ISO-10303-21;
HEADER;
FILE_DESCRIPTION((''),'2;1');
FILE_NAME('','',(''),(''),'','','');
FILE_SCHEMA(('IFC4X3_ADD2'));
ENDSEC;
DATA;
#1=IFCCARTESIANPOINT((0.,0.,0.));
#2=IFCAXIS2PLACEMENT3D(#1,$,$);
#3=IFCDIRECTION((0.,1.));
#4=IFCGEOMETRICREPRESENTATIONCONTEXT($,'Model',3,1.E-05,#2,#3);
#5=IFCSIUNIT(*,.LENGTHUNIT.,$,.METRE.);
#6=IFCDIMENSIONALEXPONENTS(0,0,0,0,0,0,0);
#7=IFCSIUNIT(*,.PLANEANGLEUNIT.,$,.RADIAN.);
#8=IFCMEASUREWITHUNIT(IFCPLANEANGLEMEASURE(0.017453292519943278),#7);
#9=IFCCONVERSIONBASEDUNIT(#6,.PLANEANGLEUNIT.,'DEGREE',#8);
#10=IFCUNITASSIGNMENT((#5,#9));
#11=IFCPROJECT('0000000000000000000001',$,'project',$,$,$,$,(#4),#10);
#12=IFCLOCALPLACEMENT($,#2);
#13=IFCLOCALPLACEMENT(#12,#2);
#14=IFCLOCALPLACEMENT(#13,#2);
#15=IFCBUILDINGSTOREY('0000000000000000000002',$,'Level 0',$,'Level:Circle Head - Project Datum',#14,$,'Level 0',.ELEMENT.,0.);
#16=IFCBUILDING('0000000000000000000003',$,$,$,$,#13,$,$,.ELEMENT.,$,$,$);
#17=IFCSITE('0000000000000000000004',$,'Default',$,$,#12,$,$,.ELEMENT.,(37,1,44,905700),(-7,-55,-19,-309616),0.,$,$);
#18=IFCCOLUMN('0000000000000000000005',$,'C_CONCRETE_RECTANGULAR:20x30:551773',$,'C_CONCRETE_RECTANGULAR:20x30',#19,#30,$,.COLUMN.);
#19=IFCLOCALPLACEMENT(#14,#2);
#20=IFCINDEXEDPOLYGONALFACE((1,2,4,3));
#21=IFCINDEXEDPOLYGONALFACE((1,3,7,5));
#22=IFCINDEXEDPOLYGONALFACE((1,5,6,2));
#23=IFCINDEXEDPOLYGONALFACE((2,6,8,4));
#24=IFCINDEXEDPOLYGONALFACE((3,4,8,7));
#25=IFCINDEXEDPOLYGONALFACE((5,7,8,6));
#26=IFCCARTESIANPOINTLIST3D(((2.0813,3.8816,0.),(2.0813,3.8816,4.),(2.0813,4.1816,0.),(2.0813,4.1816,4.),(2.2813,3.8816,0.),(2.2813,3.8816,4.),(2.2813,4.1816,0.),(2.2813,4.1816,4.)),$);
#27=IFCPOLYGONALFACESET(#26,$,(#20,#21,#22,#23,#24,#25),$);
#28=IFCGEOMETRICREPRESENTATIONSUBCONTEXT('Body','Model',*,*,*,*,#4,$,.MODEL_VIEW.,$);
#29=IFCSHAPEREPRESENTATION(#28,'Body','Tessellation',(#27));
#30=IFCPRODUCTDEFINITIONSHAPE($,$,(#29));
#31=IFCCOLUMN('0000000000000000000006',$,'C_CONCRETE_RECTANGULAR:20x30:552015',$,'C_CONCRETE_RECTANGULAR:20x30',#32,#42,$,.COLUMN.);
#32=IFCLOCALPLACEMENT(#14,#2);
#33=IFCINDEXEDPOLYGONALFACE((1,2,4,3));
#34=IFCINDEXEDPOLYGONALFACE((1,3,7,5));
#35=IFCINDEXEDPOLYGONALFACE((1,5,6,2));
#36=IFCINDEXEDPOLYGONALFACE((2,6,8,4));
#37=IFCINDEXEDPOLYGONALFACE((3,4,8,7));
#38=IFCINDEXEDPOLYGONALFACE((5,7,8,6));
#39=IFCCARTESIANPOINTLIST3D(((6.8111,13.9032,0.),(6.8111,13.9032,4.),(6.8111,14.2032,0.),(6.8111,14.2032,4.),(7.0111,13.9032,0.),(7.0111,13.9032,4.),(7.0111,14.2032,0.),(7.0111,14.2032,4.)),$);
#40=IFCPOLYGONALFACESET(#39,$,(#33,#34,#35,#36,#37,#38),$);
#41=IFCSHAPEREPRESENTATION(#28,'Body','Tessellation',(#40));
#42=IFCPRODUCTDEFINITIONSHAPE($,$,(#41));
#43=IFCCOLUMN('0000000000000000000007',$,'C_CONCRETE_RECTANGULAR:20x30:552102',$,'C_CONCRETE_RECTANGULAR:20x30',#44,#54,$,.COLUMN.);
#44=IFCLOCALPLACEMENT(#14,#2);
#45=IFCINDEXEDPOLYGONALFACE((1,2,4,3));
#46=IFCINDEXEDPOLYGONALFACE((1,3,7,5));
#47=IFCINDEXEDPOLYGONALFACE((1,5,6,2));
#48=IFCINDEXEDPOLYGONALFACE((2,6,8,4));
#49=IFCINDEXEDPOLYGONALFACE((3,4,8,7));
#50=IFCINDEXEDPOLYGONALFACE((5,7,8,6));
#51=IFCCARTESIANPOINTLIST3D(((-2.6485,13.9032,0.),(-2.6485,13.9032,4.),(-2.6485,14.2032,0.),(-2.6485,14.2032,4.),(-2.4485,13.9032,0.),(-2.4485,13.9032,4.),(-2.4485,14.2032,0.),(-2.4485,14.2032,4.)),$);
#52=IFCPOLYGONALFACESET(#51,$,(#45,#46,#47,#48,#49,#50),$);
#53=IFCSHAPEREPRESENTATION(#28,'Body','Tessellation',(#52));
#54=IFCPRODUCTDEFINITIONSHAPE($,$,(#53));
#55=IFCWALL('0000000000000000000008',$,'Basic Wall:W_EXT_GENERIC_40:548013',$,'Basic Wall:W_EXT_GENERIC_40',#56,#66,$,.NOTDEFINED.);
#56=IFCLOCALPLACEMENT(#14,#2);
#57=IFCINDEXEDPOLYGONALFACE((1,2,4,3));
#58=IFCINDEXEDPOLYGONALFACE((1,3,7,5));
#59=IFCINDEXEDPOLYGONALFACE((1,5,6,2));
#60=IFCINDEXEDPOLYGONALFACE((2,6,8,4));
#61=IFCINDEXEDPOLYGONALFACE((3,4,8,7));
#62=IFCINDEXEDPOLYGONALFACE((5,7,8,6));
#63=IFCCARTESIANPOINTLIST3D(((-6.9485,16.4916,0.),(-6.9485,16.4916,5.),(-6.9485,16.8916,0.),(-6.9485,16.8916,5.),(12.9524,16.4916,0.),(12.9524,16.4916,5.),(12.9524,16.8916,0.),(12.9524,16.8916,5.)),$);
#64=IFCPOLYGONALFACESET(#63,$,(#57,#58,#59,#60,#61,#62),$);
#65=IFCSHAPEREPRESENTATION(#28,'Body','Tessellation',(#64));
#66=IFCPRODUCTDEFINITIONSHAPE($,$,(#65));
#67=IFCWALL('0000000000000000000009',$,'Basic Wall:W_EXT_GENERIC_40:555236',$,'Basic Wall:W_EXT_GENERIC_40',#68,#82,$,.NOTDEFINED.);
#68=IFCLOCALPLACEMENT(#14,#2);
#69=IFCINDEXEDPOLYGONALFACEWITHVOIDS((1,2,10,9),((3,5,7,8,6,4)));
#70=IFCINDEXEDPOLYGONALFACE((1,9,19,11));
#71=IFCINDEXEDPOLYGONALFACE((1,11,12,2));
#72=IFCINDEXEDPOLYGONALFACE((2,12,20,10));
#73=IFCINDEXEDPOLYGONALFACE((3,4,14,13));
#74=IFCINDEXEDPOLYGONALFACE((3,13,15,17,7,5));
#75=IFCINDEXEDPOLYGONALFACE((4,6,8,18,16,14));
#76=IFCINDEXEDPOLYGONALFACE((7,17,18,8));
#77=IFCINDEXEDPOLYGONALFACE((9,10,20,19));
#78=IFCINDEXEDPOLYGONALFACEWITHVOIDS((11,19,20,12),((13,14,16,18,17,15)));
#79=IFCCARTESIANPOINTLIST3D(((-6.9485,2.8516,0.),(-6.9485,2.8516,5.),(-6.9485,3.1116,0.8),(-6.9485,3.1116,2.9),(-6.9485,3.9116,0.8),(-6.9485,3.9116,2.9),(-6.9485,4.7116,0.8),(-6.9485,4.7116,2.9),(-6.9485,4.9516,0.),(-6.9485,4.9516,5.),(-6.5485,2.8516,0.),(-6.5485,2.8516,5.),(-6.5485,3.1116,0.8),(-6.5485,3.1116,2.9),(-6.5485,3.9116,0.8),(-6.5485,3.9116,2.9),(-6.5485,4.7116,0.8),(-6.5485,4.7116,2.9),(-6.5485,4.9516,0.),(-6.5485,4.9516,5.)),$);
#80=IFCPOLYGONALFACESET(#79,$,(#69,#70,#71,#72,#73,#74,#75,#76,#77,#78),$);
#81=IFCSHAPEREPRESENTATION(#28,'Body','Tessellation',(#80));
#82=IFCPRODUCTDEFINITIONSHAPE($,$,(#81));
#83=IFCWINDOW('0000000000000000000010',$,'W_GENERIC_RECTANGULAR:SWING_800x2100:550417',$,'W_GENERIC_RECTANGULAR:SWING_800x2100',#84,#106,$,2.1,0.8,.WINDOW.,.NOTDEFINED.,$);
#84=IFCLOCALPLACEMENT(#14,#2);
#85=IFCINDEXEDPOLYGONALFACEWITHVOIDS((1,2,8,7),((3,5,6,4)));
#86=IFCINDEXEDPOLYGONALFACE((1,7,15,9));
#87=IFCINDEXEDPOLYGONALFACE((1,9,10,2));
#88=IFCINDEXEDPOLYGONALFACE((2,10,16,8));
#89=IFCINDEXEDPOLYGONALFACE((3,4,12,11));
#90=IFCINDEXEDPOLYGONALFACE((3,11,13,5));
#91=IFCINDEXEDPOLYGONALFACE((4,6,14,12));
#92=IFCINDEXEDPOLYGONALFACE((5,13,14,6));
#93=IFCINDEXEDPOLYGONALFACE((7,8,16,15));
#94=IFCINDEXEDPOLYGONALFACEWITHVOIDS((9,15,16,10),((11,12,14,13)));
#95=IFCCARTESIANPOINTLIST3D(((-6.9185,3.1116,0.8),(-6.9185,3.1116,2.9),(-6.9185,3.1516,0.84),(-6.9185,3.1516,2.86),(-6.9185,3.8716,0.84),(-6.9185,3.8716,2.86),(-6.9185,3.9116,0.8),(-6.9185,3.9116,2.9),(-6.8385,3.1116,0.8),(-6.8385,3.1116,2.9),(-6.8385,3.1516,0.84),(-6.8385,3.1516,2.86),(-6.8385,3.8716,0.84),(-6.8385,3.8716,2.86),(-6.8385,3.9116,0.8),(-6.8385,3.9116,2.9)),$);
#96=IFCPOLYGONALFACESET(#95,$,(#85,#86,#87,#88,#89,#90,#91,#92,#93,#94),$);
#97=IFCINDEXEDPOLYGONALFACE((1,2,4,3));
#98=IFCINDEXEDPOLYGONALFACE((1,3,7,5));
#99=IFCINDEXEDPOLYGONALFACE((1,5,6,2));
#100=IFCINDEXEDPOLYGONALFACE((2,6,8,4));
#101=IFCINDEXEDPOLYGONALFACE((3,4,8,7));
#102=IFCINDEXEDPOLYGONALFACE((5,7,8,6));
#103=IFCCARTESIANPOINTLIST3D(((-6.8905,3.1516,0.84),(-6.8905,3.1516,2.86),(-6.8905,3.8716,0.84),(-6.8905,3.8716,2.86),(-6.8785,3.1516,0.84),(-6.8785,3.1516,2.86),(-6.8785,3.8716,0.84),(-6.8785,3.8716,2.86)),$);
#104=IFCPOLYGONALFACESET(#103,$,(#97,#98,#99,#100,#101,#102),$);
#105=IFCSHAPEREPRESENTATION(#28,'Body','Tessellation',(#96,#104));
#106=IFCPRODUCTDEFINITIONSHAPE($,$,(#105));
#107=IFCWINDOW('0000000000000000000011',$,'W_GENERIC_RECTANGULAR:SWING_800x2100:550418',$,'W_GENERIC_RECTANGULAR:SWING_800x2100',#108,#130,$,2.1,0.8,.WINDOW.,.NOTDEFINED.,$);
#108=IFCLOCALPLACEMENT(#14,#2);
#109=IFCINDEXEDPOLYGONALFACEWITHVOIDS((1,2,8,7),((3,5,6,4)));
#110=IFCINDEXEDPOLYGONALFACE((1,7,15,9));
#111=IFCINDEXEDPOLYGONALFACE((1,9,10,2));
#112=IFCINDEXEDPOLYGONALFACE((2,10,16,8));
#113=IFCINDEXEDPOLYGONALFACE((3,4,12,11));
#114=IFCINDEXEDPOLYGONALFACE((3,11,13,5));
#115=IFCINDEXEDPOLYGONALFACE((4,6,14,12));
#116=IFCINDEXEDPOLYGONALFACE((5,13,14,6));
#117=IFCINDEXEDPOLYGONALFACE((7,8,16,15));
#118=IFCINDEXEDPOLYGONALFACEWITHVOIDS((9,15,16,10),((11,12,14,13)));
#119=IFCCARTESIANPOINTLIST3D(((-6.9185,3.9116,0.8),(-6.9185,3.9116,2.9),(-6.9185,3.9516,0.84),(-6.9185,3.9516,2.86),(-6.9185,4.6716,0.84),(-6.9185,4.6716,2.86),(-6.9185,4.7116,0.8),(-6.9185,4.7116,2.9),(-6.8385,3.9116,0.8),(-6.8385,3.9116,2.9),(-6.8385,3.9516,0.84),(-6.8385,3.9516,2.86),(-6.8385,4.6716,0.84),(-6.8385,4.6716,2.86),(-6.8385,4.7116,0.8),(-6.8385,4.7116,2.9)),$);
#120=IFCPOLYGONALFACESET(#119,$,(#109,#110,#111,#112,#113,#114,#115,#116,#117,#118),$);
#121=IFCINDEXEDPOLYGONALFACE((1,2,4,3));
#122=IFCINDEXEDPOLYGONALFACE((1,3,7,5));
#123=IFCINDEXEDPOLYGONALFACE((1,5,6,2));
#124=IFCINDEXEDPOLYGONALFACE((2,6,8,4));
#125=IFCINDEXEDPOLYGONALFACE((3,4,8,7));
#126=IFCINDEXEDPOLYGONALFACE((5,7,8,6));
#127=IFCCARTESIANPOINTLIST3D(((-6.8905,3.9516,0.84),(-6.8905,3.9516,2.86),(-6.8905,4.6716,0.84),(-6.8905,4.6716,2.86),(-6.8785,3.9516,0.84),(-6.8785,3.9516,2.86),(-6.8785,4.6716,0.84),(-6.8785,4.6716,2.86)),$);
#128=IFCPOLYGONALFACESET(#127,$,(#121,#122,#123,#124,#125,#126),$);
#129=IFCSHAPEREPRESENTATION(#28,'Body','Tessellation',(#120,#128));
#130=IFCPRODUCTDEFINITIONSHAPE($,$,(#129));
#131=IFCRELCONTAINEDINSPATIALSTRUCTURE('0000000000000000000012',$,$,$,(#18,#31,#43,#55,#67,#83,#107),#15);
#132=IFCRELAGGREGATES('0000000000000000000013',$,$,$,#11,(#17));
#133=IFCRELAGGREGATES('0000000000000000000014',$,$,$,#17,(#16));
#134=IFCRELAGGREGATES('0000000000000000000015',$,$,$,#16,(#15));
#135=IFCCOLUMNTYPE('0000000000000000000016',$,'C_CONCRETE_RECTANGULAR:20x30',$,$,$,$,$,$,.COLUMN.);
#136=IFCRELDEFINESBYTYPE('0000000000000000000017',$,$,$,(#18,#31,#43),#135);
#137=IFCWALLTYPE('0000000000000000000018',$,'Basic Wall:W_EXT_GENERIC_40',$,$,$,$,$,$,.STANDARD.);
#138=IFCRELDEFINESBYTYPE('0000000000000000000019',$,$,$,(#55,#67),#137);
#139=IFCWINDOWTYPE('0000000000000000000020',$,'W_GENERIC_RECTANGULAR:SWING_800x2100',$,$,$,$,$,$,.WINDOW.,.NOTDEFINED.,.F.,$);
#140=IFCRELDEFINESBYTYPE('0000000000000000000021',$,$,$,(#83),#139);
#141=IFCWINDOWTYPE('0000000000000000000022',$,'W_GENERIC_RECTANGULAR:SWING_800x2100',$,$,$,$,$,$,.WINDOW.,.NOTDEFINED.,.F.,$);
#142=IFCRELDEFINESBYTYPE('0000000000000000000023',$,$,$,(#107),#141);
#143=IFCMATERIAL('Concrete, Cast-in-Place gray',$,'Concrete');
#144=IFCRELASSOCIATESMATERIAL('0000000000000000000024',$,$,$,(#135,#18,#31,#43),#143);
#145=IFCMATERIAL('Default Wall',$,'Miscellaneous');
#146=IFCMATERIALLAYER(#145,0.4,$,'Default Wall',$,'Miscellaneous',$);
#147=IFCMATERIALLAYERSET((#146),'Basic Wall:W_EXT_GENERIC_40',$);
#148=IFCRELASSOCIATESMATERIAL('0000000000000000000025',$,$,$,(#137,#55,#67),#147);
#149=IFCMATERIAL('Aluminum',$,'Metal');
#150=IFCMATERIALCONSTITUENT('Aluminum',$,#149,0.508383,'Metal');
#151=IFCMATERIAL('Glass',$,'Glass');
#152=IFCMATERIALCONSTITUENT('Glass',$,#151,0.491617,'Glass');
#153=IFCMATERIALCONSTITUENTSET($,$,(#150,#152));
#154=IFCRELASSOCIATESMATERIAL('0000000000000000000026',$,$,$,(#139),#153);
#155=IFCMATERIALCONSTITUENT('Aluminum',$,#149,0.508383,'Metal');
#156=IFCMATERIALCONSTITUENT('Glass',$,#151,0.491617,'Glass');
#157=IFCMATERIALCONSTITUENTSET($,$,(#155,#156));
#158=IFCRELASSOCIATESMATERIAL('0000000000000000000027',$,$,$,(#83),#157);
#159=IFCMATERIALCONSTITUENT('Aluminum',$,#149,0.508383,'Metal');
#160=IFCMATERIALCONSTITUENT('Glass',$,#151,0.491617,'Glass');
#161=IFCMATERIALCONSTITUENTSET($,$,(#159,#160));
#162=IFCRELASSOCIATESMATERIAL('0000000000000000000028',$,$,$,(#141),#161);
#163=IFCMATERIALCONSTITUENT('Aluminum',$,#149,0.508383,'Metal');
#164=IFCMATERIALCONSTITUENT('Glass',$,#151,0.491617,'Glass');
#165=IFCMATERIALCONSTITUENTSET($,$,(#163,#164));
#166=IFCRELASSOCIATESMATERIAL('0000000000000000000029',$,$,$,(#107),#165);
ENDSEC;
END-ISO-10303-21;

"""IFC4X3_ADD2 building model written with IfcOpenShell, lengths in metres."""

from ifc_helpers import new_model, entity, si_unit, converted_unit, direction, frame, frame_2d, origin, origin_2d_with_axis, place, context, subcontext, project, spatial, polyline, rectangle, outline, extrude, source, transform, mapped, material, layer, layer_set, constituent, constituent_set, material_profile, profile_set, profile_usage, type_object, type_shapes, element, fill, save


model = new_model("IFC4X3_ADD2")

# Units and contexts
model_context = context("Model", 3, precision=1e-05, world=origin(), true_north=direction((0.0, 1.0)))
body_context = subcontext(model_context, "Body", "Model", "MODEL_VIEW")
ifc_project = project(units=[si_unit("LENGTHUNIT", "METRE"), converted_unit("PLANEANGLEUNIT", "DEGREE", entity("IfcPlaneAngleMeasure", 0.017453292519943278), si_unit("PLANEANGLEUNIT", "RADIAN"), dimensions=[0, 0, 0, 0, 0, 0, 0])], contexts=[model_context])

# Site, building, storey
site_placement = place(None, origin())
site = spatial("IfcSite", under=ifc_project, at=site_placement, Name="Default", CompositionType="ELEMENT", RefLatitude=(37, 1, 44, 905700), RefLongitude=(-7, -55, -19, -309616), RefElevation=0.0)
building_placement = place(site_placement, origin())
building = spatial("IfcBuilding", under=site, at=building_placement, CompositionType="ELEMENT")
storey_placement = place(building_placement, origin())
storey = spatial("IfcBuildingStorey", under=building, at=storey_placement, Name="Level 0", ObjectType="Level:Circle Head - Project Datum", LongName="Level 0", CompositionType="ELEMENT", Elevation=0.0)

# Columns
ifc_material_1 = material(Name="Concrete, Cast-in-Place gray", Category="Concrete")
ifc_material_profile = material_profile(ifc_material_1, rectangle(XDim=0.2, YDim=0.3, at=origin_2d_with_axis()), Name="20x30")
ifc_profile_set = profile_set([ifc_material_profile], Name="20x30")
ifc_profile_usage = profile_usage(ifc_profile_set)
column_type = type_object("IfcColumnType", Name="C_CONCRETE_RECTANGULAR:20x30", PredefinedType="COLUMN", material=ifc_profile_set)
shared_shape_1 = source(origin(), body_context, "Body", "SweptSolid", [
    extrude(rectangle(XDim=0.2, YDim=0.3, at=origin_2d_with_axis()), frame((0.0, 0.0, 0.0), z_axis=(0.0, 0.0, 1.0), x_axis=(-1.0, 0.0, 0.0)), (0.0, 0.0, 1.0), 4.0),
])
type_shapes(column_type, [shared_shape_1])
for number, where, name in (
    (1, (2.1813, 4.0316, 0.0), "C_CONCRETE_RECTANGULAR:20x30:551773"),
    (2, (6.9111, 14.0532, 0.0), "C_CONCRETE_RECTANGULAR:20x30:552015"),
    (3, (-2.5485, 14.0532, 0.0), "C_CONCRETE_RECTANGULAR:20x30:552102"),
):
    element("IfcColumn", number, at=place(storey_placement, frame(where)), inside=storey, type_object=column_type, material=ifc_profile_usage, Name=name, ObjectType="C_CONCRETE_RECTANGULAR:20x30", PredefinedType="COLUMN", context=body_context, shape_type="MappedRepresentation", body=[
        mapped(shared_shape_1, transform((0.0, 0.0, 0.0), scale=1.0)),
    ])

# Wall
ifc_material_2 = material(Name="Default Wall", Category="Miscellaneous")
ifc_layer_1 = layer(ifc_material_2, 0.4, Name="Default Wall", Category="Miscellaneous")
ifc_layer_set_1 = layer_set([ifc_layer_1], Name="Basic Wall:W_EXT_GENERIC_40")
wall_type_1 = type_object("IfcWallType", Name="Basic Wall:W_EXT_GENERIC_40", PredefinedType="STANDARD", material=ifc_layer_set_1)
wall_1_placement = place(storey_placement, frame((-6.9485, 16.6916, 0.0)))
element("IfcWall", 4, at=wall_1_placement, inside=storey, type_object=wall_type_1, material=ifc_layer_set_1, Name="Basic Wall:W_EXT_GENERIC_40:548013", ObjectType="Basic Wall:W_EXT_GENERIC_40", PredefinedType="NOTDEFINED", context=body_context, shape_type="SweptSolid", body=[
    extrude(rectangle(XDim=19.9008, YDim=0.4, at=frame_2d((9.9504, 0.0), x_axis=(-1.0, 0.0))), origin(), (0.0, 0.0, 1.0), 5.0),
])

# Wall, openings, windows
wall_2_placement = place(storey_placement, frame((-6.7485, 4.9516, 0.0), z_axis=(0.0, 0.0, 1.0), x_axis=(0.0, -1.0, 0.0)))
wall_2 = element("IfcWall", 5, at=wall_2_placement, inside=storey, type_object=wall_type_1, material=ifc_layer_set_1, Name="Basic Wall:W_EXT_GENERIC_40:555236", ObjectType="Basic Wall:W_EXT_GENERIC_40", PredefinedType="NOTDEFINED", context=body_context, shape_type="SweptSolid", body=[
    extrude(rectangle(XDim=2.1, YDim=0.4, at=frame_2d((1.05, 0.0), x_axis=(-1.0, 0.0))), origin(), (0.0, 0.0, 1.0), 5.0),
])
opening_1_placement = place(wall_2_placement, frame((1.04, -0.2, 0.8)))
opening_1 = element("IfcOpeningElement", 6, at=opening_1_placement, cuts=wall_2, PredefinedType="OPENING", context=body_context, shape_type="SweptSolid", body=[
    extrude(rectangle(XDim=2.1, YDim=0.8, at=frame_2d((1.05, 0.4), x_axis=(-1.0, 0.0))), frame((0.0, 0.0, 0.0), z_axis=(0.0, 1.0, 0.0), x_axis=(0.0, 0.0, 1.0)), (0.0, 0.0, 1.0), 0.4),
])
opening_2_placement = place(wall_2_placement, frame((4.9516, 6.7485, 0.8), z_axis=(0.0, 0.0, 1.0), x_axis=(0.0, 1.0, 0.0)))
element("IfcOpeningElement", 7, at=opening_2_placement, cuts=wall_2, PredefinedType="OPENING", context=body_context, shape_type="SweptSolid", body=[
    extrude(rectangle(XDim=2.1, YDim=0.8, at=origin_2d_with_axis()), frame((-8.4725, 3.5116, 1.05), z_axis=(1.0, 0.0, 0.0), x_axis=(0.0, 0.0, -1.0)), (0.0, 0.0, 1.0), 3.048),
])
opening_3_placement = place(wall_2_placement, frame((0.24, -0.2, 0.8)))
opening_3 = element("IfcOpeningElement", 8, at=opening_3_placement, cuts=wall_2, PredefinedType="OPENING", context=body_context, shape_type="SweptSolid", body=[
    extrude(rectangle(XDim=2.1, YDim=0.8, at=frame_2d((1.05, 0.4), x_axis=(-1.0, 0.0))), frame((0.0, 0.0, 0.0), z_axis=(0.0, 1.0, 0.0), x_axis=(0.0, 0.0, 1.0)), (0.0, 0.0, 1.0), 0.4),
])
opening_4_placement = place(wall_2_placement, frame((4.9516, 6.7485, 0.8), z_axis=(0.0, 0.0, 1.0), x_axis=(0.0, 1.0, 0.0)))
element("IfcOpeningElement", 9, at=opening_4_placement, cuts=wall_2, PredefinedType="OPENING", context=body_context, shape_type="SweptSolid", body=[
    extrude(rectangle(XDim=2.1, YDim=0.8, at=frame_2d((0.0, 0.0), x_axis=(0.0, 1.0))), frame((-8.4725, 4.3116, 1.05), z_axis=(1.0, 0.0, 0.0), x_axis=(0.0, -1.0, 0.0)), (0.0, 0.0, 1.0), 3.048),
])
ifc_material_3 = material(Name="Aluminum", Category="Metal")
ifc_constituent_1 = constituent(ifc_material_3, Name="Aluminum", Category="Metal", fraction=0.508383)
ifc_material_4 = material(Name="Glass", Category="Glass")
ifc_constituent_2 = constituent(ifc_material_4, Name="Glass", Category="Glass", fraction=0.491617)
ifc_constituent_set_1 = constituent_set(constituents=[ifc_constituent_1, ifc_constituent_2])
ifc_constituent_3 = constituent(ifc_material_3, Name="Aluminum", Category="Metal", fraction=0.508383)
ifc_constituent_4 = constituent(ifc_material_4, Name="Glass", Category="Glass", fraction=0.491617)
ifc_constituent_set_2 = constituent_set(constituents=[ifc_constituent_3, ifc_constituent_4])
window_type_1 = type_object("IfcWindowType", Name="W_GENERIC_RECTANGULAR:SWING_800x2100", ParameterTakesPrecedence=False, PartitioningType="NOTDEFINED", PredefinedType="WINDOW", material=ifc_constituent_set_2)
shared_shape_2 = source(origin(), body_context, "Body", "SweptSolid", [
    extrude(outline(polyline([(-0.4, -1.05), (0.4, -1.05), (0.4, 1.05), (-0.4, 1.05), (-0.4, -1.05)]), holes=[polyline([(-0.36, 1.01), (0.36, 1.01), (0.36, -1.01), (-0.36, -1.01), (-0.36, 1.01)])]), frame((0.15, 0.11, 1.05), z_axis=(0.0, -1.0, 0.0), x_axis=(1.0, 0.0, 0.0)), (0.0, 0.0, 1.0), 0.08),
    extrude(rectangle(XDim=0.012, YDim=0.72, at=frame_2d((0.0, 0.0), x_axis=(1.0, 0.0))), frame((0.15, 0.064, 0.04), z_axis=(0.0, 0.0, 1.0), x_axis=(0.0, -1.0, 0.0)), (0.0, 0.0, 1.0), 2.02),
])
type_shapes(window_type_1, [shared_shape_2])
window_1_placement = place(opening_1_placement, frame((0.25, 0.0, 0.0)))
window_1 = element("IfcWindow", 10, at=window_1_placement, inside=storey, type_object=window_type_1, material=ifc_constituent_set_1, Name="W_GENERIC_RECTANGULAR:SWING_800x2100:550417", ObjectType="W_GENERIC_RECTANGULAR:SWING_800x2100", OverallHeight=2.1, OverallWidth=0.8, PartitioningType="NOTDEFINED", PredefinedType="WINDOW", context=body_context, shape_type="MappedRepresentation", body=[
    mapped(shared_shape_2, transform((0.0, 0.0, 0.0), scale=1.0)),
])
fill(opening_1, window_1)
ifc_constituent_5 = constituent(ifc_material_3, Name="Aluminum", Category="Metal", fraction=0.508383)
ifc_constituent_6 = constituent(ifc_material_4, Name="Glass", Category="Glass", fraction=0.491617)
ifc_constituent_set_3 = constituent_set(constituents=[ifc_constituent_5, ifc_constituent_6])
ifc_constituent_7 = constituent(ifc_material_3, Name="Aluminum", Category="Metal", fraction=0.508383)
ifc_constituent_8 = constituent(ifc_material_4, Name="Glass", Category="Glass", fraction=0.491617)
ifc_constituent_set_4 = constituent_set(constituents=[ifc_constituent_7, ifc_constituent_8])
window_type_2 = type_object("IfcWindowType", Name="W_GENERIC_RECTANGULAR:SWING_800x2100", ParameterTakesPrecedence=False, PartitioningType="NOTDEFINED", PredefinedType="WINDOW", material=ifc_constituent_set_4)
shared_shape_3 = source(origin(), body_context, "Body", "SweptSolid", [
    extrude(outline(polyline([(-1.05, -0.4), (1.05, -0.4), (1.05, 0.4), (-1.05, 0.4), (-1.05, -0.4)]), holes=[polyline([(1.01, -0.36), (-1.01, -0.36), (-1.01, 0.36), (1.01, 0.36), (1.01, -0.36)])]), frame((0.4, 0.03, 1.05), z_axis=(0.0, 1.0, 0.0), x_axis=(0.0, 0.0, -1.0)), (0.0, 0.0, 1.0), 0.08),
    extrude(rectangle(XDim=0.72, YDim=0.012, at=frame_2d((0.0, 0.0), x_axis=(1.0, 0.0))), frame((0.4, 0.064, 0.04), z_axis=(0.0, 0.0, 1.0), x_axis=(-1.0, 0.0, 0.0)), (0.0, 0.0, 1.0), 2.02),
])
type_shapes(window_type_2, [shared_shape_3])
window_2_placement = place(opening_3_placement, origin())
window_2 = element("IfcWindow", 11, at=window_2_placement, inside=storey, type_object=window_type_2, material=ifc_constituent_set_3, Name="W_GENERIC_RECTANGULAR:SWING_800x2100:550418", ObjectType="W_GENERIC_RECTANGULAR:SWING_800x2100", OverallHeight=2.1, OverallWidth=0.8, PartitioningType="NOTDEFINED", PredefinedType="WINDOW", context=body_context, shape_type="MappedRepresentation", body=[
    mapped(shared_shape_3, transform((0.0, 0.0, 0.0), scale=1.0)),
])
fill(opening_3, window_2)

save(model, "model.ifc")
